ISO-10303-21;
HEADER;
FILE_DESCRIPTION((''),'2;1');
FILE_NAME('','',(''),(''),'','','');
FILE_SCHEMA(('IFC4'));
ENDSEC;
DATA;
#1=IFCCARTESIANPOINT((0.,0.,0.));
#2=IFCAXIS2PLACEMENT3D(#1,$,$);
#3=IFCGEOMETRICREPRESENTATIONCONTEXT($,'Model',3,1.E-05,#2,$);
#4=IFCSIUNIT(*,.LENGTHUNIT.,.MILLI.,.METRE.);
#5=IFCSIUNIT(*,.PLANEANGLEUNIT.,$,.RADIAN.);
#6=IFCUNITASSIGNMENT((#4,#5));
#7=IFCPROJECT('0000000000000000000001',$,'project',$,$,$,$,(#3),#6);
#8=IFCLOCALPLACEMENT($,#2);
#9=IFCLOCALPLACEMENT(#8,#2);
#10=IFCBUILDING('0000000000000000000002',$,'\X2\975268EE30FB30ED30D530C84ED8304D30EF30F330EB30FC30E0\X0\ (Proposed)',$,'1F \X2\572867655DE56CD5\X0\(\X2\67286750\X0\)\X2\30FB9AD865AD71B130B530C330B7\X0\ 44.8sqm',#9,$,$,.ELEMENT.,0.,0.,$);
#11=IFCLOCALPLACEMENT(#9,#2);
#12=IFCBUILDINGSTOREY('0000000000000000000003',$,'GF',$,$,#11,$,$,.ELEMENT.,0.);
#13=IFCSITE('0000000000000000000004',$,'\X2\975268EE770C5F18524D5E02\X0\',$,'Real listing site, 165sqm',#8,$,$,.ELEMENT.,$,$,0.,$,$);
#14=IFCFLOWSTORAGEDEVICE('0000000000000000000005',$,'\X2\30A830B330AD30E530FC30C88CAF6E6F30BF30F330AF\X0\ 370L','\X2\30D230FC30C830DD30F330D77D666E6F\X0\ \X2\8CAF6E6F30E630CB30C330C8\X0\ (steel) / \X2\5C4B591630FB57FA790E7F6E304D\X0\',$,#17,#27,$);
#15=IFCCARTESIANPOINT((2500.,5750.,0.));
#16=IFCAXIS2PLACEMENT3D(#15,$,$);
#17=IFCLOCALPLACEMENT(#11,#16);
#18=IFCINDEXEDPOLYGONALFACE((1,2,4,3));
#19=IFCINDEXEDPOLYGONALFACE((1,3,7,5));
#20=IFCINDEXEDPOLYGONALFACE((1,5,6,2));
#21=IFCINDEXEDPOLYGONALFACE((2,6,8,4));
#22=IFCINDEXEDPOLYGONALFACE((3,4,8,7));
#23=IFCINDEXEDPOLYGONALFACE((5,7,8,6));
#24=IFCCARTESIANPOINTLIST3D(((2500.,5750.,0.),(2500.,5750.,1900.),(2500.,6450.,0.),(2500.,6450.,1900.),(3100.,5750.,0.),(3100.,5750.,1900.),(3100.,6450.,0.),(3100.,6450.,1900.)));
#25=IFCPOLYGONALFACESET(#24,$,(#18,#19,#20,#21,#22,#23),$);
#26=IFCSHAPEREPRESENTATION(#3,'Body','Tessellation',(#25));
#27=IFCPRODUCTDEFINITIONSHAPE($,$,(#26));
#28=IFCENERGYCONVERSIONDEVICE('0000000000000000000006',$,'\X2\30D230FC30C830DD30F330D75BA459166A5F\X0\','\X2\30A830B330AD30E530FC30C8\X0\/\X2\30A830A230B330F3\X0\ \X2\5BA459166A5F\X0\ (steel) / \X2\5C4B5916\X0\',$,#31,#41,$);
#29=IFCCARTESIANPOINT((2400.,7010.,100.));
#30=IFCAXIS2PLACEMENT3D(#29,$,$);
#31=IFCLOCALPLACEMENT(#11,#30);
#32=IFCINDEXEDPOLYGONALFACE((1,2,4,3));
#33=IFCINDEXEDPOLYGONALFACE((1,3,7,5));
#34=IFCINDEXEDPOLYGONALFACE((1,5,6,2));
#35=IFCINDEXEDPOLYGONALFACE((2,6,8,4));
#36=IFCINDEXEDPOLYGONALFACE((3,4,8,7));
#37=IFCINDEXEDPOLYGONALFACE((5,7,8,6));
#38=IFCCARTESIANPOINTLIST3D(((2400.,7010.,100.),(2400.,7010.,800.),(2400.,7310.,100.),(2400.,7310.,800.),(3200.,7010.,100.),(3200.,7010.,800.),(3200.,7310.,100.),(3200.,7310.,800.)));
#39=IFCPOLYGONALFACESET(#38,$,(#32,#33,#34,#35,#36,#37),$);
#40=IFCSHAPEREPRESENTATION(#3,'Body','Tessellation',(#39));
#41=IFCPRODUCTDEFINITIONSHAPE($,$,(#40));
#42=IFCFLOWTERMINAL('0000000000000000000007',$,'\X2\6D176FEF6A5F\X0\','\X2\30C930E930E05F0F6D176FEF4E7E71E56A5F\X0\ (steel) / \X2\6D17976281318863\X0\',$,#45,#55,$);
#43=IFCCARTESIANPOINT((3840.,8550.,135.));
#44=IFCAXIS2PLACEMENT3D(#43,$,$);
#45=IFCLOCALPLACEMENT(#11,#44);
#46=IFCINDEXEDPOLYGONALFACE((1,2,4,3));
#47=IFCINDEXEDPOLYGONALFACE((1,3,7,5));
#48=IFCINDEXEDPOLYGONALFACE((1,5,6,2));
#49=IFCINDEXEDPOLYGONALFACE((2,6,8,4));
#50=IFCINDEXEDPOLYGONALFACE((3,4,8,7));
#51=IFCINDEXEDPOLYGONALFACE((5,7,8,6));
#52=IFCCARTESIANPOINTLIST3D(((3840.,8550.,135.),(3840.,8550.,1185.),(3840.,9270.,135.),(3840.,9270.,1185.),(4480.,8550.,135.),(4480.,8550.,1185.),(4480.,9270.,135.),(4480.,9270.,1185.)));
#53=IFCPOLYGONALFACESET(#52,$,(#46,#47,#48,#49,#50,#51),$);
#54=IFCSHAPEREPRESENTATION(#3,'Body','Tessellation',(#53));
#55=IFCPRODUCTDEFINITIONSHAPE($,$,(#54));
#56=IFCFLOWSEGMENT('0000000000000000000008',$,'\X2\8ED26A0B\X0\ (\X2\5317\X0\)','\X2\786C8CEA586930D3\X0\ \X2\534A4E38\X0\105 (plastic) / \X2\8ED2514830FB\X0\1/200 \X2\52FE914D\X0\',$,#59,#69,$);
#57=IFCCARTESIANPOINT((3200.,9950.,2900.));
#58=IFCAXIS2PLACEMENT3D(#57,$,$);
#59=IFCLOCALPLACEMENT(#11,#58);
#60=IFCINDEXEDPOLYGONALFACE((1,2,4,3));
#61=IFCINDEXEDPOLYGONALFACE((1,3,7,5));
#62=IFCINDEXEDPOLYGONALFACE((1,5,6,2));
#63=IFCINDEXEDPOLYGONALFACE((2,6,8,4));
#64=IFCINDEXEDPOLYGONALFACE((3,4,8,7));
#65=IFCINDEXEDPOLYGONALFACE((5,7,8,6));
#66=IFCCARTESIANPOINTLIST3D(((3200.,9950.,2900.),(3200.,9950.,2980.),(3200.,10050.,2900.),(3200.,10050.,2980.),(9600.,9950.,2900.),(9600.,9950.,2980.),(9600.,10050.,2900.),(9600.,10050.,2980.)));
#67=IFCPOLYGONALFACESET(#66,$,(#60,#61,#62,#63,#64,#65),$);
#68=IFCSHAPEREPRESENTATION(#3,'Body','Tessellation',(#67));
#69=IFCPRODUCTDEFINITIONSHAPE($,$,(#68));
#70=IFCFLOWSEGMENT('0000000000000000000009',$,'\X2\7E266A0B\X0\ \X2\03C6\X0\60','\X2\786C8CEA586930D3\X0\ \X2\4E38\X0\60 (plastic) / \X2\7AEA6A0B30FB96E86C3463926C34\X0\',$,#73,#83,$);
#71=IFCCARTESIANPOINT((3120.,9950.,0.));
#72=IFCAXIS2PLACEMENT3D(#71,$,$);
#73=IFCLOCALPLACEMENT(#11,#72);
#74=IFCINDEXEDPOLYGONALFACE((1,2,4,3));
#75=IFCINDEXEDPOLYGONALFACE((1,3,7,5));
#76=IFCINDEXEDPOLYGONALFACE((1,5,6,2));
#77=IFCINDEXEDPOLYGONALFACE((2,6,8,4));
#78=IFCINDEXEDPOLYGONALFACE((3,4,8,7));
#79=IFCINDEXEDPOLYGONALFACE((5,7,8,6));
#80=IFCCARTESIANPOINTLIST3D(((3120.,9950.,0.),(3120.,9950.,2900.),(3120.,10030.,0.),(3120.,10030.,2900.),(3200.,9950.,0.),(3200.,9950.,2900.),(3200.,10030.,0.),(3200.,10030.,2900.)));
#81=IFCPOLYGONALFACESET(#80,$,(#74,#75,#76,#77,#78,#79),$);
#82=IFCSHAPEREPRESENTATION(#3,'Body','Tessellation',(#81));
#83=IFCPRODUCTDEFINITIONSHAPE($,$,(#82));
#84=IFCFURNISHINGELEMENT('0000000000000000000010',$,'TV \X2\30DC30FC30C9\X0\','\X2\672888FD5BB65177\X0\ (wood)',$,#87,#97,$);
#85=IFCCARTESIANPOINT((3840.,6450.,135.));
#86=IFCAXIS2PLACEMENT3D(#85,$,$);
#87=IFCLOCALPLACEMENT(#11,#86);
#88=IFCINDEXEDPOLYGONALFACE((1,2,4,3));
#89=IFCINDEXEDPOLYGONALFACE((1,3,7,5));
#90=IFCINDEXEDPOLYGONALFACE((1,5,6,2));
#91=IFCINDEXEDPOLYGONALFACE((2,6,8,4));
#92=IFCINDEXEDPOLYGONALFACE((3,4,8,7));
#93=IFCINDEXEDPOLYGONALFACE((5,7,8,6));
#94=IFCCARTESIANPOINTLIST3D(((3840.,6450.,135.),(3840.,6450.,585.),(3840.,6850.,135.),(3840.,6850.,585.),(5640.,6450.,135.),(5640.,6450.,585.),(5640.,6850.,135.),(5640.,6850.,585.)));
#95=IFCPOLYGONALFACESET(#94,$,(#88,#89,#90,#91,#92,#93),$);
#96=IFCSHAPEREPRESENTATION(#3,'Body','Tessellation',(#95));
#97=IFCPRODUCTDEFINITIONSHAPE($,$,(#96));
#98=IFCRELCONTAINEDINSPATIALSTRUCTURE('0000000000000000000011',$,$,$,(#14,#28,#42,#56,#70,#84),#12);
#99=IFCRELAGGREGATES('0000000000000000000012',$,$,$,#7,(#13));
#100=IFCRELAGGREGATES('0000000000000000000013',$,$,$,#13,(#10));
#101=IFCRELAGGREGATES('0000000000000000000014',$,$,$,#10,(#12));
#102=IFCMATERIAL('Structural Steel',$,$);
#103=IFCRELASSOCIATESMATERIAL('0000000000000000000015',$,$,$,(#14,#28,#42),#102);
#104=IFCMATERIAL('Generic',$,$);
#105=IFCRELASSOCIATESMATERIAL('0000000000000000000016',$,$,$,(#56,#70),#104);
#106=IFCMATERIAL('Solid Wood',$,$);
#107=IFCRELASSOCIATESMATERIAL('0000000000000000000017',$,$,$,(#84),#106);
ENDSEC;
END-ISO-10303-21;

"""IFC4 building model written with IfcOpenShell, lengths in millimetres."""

from ifc_helpers import new_model, si_unit, frame, frame_2d, origin, place, context, project, spatial, rectangle, extrude, material, element, save


model = new_model("IFC4")

# Units and contexts
model_context = context("Model", 3, precision=1e-05, world=origin())
ifc_project = project(units=[si_unit("LENGTHUNIT", "METRE", prefix="MILLI"), si_unit("PLANEANGLEUNIT", "RADIAN")], contexts=[model_context])

# Site, building, storey
site_placement = place(None, origin())
site = spatial("IfcSite", under=ifc_project, at=site_placement, Name="青森県弘前市", ObjectType="Real listing site, 165sqm", CompositionType="ELEMENT", RefElevation=0.0)
building_placement = place(site_placement, origin())
building = spatial("IfcBuilding", under=site, at=building_placement, Name="青森・ロフト付きワンルーム (Proposed)", ObjectType="1F 在来工法(木材)・高断熱サッシ 44.8sqm", CompositionType="ELEMENT", ElevationOfRefHeight=0.0, ElevationOfTerrain=0.0)
storey_placement = place(building_placement, origin())
storey = spatial("IfcBuildingStorey", under=building, at=storey_placement, Name="GF", CompositionType="ELEMENT", Elevation=0.0)

# Shared definitions
ifc_material_1 = material(Name="Solid Wood")

# Shared definitions
ifc_material_2 = material(Name="Structural Steel")

# Shared definitions
ifc_material_3 = material(Name="Generic")

# Flow storage device
flow_storage_device_placement = place(storey_placement, frame((2500.0, 5750.0, 0.0)))
element("IfcFlowStorageDevice", 1, at=flow_storage_device_placement, inside=storey, material=ifc_material_2, Name="エコキュート貯湯タンク 370L", Description="ヒートポンプ給湯 貯湯ユニット (steel) / 屋外・基礎置き", context=model_context, shape_type="SweptSolid", body=[
    extrude(rectangle(XDim=600.0, YDim=700.0, at=frame_2d((300.0, 350.0))), frame((2500.0, 5750.0, 0.0)), (0.0, 0.0, 1.0), 1900.0),
])

# Energy conversion device
energy_conversion_device_placement = place(storey_placement, frame((2400.0, 7010.0, 100.0)))
element("IfcEnergyConversionDevice", 2, at=energy_conversion_device_placement, inside=storey, material=ifc_material_2, Name="ヒートポンプ室外機", Description="エコキュート/エアコン 室外機 (steel) / 屋外", context=model_context, shape_type="SweptSolid", body=[
    extrude(rectangle(XDim=800.0, YDim=300.0, at=frame_2d((400.0, 150.0))), frame((2400.0, 7010.0, 100.0)), (0.0, 0.0, 1.0), 700.0),
])

# Flow terminal
flow_terminal_placement = place(storey_placement, frame((3840.0, 8550.0, 135.0)))
element("IfcFlowTerminal", 3, at=flow_terminal_placement, inside=storey, material=ifc_material_2, Name="洗濯機", Description="ドラム式洗濯乾燥機 (steel) / 洗面脱衣", context=model_context, shape_type="SweptSolid", body=[
    extrude(rectangle(XDim=640.0, YDim=720.0, at=frame_2d((320.0, 360.0))), frame((3840.0, 8550.0, 135.0)), (0.0, 0.0, 1.0), 1050.0),
])

# Flow segments
flow_segment_1_placement = place(storey_placement, frame((3200.0, 9950.0, 2900.0)))
element("IfcFlowSegment", 4, at=flow_segment_1_placement, inside=storey, material=ifc_material_3, Name="軒樋 (北)", Description="硬質塩ビ 半丸105 (plastic) / 軒先・1/200 勾配", context=model_context, shape_type="SweptSolid", body=[
    extrude(rectangle(XDim=6400.0, YDim=100.0, at=frame_2d((3200.0, 50.0))), frame((3200.0, 9950.0, 2900.0)), (0.0, 0.0, 1.0), 80.0),
])
flow_segment_2_placement = place(storey_placement, frame((3120.0, 9950.0, 0.0)))
element("IfcFlowSegment", 5, at=flow_segment_2_placement, inside=storey, material=ifc_material_3, Name="縦樋 φ60", Description="硬質塩ビ 丸60 (plastic) / 竪樋・雨水排水", context=model_context, shape_type="SweptSolid", body=[
    extrude(rectangle(XDim=80.0, YDim=80.0, at=frame_2d((40.0, 40.0))), frame((3120.0, 9950.0, 0.0)), (0.0, 0.0, 1.0), 2900.0),
])

# Furnishing element
furnishing_placement = place(storey_placement, frame((3840.0, 6450.0, 135.0)))
element("IfcFurnishingElement", 6, at=furnishing_placement, inside=storey, material=ifc_material_1, Name="TV ボード", Description="木製家具 (wood)", context=model_context, shape_type="SweptSolid", body=[
    extrude(rectangle(XDim=1800.0, YDim=400.0, at=frame_2d((900.0, 200.0))), frame((3840.0, 6450.0, 135.0)), (0.0, 0.0, 1.0), 450.0),
])

save(model, "model.ifc")
